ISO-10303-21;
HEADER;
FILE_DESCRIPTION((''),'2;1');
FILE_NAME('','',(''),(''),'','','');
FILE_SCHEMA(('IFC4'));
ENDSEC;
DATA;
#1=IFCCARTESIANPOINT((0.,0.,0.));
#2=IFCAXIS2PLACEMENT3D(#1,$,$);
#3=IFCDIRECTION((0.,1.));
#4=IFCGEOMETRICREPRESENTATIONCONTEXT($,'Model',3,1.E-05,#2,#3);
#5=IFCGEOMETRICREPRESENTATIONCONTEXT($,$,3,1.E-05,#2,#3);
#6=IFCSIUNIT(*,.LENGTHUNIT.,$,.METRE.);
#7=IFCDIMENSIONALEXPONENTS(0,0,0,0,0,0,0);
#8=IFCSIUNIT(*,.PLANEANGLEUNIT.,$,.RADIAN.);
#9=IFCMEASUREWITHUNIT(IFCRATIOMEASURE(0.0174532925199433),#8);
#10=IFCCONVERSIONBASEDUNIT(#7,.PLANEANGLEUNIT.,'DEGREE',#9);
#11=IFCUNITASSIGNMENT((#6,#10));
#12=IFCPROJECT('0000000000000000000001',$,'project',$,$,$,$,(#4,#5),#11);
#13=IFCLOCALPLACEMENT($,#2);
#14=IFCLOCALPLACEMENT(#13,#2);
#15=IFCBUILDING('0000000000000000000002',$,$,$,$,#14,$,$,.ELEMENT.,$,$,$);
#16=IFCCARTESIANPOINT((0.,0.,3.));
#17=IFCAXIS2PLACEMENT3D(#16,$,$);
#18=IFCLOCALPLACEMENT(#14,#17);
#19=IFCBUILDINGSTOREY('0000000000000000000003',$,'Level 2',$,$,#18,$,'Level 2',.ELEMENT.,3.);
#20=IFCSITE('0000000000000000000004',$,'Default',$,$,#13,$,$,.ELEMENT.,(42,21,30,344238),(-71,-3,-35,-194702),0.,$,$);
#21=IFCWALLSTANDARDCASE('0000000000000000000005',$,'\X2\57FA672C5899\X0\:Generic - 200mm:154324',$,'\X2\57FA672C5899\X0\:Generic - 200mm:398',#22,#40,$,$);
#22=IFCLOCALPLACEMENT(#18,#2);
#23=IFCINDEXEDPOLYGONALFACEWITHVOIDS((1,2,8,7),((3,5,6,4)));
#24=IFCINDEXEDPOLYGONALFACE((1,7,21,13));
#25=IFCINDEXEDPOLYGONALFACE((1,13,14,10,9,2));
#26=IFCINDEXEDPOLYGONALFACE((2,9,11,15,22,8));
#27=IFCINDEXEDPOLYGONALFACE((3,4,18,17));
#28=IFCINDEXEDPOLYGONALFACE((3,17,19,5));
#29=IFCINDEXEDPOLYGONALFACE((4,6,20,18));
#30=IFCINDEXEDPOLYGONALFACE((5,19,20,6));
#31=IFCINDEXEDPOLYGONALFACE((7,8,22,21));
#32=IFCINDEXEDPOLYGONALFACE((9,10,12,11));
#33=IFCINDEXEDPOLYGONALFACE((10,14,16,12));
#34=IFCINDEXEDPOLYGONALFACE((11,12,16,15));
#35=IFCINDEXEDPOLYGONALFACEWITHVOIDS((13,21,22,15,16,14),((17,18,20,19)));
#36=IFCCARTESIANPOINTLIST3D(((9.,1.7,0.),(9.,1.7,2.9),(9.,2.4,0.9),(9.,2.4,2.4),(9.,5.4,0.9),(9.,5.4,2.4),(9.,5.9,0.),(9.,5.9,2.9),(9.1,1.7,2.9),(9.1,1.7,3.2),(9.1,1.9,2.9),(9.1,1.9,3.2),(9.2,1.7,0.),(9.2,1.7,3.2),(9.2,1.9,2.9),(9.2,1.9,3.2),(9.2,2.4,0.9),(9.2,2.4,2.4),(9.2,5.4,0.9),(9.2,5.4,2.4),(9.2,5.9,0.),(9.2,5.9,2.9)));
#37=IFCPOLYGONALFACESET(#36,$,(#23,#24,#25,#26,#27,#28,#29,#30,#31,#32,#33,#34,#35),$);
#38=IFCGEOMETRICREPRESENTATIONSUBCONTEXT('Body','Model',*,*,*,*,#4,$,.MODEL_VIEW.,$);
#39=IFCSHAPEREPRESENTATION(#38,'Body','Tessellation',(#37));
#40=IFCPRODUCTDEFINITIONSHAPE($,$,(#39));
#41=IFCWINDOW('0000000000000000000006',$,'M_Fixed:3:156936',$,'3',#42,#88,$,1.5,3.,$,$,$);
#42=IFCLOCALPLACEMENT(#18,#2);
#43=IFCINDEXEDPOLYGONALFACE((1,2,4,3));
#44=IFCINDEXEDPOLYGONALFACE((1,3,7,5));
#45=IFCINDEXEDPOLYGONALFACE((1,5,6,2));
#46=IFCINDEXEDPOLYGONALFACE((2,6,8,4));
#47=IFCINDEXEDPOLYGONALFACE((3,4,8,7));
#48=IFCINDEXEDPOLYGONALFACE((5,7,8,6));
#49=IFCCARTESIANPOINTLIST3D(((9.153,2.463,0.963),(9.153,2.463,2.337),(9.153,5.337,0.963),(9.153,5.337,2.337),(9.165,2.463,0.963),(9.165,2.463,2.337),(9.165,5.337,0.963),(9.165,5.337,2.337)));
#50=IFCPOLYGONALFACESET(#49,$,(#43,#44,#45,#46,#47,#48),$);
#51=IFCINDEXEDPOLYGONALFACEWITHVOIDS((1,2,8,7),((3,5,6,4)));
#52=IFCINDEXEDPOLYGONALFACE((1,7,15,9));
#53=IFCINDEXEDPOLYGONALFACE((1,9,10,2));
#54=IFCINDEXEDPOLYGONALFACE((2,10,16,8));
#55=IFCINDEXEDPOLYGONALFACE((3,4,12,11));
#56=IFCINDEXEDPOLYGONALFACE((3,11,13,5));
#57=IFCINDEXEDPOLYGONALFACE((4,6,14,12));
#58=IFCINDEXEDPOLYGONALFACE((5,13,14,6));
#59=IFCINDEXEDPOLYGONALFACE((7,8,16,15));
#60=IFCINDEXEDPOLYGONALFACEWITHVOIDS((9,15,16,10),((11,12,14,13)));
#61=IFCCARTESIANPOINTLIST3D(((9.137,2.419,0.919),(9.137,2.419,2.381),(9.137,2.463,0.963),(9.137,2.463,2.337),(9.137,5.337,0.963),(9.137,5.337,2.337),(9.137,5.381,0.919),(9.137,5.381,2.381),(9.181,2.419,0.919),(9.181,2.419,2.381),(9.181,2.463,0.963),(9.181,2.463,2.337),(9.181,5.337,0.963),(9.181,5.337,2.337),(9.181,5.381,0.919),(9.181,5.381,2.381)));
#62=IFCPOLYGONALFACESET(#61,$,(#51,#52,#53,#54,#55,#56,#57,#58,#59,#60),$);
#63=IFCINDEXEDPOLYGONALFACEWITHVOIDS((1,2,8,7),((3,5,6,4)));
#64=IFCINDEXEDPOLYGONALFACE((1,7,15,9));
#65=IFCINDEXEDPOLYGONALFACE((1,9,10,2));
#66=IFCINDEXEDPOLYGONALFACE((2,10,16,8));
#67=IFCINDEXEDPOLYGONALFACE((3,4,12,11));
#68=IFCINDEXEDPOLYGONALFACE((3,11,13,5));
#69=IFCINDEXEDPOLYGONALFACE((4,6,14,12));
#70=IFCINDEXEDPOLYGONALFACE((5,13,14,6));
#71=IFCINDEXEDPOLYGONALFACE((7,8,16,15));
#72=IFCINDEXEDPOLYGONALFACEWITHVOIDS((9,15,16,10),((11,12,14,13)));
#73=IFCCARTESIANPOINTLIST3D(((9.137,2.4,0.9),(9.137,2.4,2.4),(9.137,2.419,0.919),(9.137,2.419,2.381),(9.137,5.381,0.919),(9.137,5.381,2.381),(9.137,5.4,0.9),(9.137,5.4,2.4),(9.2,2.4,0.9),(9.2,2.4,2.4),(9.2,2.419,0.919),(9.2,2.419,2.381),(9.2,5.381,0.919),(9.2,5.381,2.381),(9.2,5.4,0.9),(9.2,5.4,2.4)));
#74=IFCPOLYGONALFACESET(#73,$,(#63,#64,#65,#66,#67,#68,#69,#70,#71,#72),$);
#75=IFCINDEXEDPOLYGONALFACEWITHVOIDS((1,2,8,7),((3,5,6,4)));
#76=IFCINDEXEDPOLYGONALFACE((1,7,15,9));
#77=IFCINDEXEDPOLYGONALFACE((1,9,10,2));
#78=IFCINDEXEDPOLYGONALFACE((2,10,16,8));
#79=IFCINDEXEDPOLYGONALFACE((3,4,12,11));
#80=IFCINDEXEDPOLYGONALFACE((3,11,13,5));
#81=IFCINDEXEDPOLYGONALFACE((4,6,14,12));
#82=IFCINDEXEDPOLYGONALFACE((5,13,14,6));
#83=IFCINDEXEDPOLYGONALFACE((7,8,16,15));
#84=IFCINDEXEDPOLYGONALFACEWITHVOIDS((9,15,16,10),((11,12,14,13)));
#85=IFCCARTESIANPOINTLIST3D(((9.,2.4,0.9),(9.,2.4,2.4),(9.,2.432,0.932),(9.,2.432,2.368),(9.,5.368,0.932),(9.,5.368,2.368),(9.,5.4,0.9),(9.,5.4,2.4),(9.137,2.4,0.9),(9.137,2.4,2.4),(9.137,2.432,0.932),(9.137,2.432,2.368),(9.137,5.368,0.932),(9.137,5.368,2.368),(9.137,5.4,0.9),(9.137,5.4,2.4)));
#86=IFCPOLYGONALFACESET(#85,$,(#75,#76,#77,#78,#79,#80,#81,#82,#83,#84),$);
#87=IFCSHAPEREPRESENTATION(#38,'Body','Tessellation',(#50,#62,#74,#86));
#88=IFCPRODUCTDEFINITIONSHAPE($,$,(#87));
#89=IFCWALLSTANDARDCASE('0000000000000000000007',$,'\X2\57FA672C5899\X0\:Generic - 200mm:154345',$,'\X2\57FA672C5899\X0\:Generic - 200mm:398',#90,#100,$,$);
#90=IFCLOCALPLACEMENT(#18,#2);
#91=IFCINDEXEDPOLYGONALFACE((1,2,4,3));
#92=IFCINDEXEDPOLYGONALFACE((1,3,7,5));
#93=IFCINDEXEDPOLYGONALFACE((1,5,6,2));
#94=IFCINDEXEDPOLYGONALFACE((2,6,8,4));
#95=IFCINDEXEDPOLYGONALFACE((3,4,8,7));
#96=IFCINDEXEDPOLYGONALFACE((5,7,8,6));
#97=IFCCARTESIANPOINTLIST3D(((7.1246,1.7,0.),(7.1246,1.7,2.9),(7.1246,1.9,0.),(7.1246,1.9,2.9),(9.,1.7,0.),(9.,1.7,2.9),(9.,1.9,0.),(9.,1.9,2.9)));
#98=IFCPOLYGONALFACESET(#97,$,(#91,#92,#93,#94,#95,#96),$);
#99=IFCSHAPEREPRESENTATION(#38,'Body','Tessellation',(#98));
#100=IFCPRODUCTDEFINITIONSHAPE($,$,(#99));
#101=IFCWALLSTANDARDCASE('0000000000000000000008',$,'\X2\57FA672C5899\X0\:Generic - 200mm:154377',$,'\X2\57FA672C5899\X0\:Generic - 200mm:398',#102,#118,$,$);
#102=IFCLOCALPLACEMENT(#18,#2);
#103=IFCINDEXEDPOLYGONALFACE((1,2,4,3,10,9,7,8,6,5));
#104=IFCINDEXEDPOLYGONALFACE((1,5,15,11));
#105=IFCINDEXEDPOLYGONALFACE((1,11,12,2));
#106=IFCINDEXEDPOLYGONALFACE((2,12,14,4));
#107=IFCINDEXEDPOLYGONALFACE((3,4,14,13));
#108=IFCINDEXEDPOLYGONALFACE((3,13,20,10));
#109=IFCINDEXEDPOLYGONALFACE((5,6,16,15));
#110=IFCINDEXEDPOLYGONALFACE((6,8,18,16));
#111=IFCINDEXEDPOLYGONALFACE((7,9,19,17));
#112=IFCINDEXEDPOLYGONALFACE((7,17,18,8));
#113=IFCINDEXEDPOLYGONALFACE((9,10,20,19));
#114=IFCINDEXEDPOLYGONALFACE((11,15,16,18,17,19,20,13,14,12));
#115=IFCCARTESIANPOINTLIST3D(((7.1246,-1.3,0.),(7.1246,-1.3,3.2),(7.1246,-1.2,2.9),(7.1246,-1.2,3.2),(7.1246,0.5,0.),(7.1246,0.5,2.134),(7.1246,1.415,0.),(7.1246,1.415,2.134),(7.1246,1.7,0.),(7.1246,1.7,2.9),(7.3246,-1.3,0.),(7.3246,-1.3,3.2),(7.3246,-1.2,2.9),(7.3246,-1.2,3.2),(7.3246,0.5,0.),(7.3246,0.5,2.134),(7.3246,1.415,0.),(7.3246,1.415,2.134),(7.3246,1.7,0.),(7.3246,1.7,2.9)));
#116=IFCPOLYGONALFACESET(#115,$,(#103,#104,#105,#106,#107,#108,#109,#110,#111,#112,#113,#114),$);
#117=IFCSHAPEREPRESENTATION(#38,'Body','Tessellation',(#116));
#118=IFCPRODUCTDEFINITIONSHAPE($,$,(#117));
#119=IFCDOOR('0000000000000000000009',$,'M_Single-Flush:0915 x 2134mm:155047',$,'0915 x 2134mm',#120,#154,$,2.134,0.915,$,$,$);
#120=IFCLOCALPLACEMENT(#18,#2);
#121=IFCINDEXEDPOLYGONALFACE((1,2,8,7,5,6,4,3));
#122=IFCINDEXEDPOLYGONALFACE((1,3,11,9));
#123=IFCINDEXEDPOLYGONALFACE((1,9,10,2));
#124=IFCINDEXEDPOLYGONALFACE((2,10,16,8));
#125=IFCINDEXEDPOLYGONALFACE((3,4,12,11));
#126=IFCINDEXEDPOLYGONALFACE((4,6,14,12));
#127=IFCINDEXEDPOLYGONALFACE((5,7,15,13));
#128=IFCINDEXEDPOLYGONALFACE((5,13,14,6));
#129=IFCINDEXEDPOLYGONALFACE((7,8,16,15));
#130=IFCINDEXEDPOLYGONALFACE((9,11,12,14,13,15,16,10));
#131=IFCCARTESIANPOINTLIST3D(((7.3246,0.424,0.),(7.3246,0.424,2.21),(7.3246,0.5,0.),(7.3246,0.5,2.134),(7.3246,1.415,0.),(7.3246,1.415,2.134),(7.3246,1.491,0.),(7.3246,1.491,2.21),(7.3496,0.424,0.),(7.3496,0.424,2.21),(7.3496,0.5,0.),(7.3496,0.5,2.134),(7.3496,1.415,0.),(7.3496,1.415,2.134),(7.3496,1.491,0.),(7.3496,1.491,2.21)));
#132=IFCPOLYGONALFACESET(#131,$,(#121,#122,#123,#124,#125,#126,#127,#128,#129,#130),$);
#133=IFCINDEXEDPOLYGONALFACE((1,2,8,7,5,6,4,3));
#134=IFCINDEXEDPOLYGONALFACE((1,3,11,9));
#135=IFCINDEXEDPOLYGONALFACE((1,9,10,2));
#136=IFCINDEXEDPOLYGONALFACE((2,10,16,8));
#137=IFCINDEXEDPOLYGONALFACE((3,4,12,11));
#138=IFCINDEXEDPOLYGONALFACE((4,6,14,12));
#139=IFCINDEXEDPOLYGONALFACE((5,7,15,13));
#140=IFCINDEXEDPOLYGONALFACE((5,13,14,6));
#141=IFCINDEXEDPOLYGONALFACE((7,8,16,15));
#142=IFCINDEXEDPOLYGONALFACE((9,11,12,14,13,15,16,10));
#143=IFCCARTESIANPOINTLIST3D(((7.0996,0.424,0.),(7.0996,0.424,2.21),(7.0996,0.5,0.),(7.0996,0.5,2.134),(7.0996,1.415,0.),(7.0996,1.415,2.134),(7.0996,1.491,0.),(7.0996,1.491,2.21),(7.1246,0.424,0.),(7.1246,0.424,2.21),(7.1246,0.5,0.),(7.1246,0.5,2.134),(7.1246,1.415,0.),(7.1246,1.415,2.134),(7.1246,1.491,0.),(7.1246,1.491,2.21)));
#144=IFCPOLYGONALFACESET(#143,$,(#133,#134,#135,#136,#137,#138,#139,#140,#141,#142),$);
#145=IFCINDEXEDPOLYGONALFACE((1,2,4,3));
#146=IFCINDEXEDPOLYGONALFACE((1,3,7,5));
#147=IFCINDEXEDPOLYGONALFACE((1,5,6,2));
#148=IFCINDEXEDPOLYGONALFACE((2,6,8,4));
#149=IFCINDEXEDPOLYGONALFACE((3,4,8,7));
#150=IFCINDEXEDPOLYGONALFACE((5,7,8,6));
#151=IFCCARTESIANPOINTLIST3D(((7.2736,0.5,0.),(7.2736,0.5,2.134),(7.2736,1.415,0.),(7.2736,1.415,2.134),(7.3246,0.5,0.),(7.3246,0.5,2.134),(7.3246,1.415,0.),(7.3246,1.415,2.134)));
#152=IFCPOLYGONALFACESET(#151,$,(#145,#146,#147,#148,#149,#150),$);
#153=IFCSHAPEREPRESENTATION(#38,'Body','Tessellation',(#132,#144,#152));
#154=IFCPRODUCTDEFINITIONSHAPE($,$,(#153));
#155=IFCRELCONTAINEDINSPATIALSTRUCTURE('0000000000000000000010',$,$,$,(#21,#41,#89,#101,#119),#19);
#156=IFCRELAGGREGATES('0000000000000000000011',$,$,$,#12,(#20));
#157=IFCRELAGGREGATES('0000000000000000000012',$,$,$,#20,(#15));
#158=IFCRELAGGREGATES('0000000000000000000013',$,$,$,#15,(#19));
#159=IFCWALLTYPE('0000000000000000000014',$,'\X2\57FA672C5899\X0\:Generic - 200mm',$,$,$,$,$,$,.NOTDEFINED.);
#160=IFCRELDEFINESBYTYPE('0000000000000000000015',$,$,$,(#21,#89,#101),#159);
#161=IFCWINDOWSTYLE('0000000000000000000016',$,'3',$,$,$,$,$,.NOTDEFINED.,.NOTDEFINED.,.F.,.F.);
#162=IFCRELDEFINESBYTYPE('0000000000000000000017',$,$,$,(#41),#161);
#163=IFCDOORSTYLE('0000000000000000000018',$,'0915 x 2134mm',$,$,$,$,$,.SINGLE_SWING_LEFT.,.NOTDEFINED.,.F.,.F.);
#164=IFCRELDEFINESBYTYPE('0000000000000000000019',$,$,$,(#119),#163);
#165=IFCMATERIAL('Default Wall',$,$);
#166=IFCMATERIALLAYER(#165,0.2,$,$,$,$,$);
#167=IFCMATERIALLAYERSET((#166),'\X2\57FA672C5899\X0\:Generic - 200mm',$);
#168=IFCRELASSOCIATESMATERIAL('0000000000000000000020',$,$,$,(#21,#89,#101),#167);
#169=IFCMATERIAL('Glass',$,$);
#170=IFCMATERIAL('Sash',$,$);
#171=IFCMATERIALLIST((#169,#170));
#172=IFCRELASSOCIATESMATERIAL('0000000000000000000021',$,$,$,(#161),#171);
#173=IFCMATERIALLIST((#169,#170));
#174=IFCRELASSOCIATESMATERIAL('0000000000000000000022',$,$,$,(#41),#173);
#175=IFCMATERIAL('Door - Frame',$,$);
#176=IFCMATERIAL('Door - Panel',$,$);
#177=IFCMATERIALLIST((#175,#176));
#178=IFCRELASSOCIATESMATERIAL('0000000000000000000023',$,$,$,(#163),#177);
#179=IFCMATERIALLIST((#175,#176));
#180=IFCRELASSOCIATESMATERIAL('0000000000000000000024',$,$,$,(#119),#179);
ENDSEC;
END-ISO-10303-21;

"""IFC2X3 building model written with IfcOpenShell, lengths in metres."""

from ifc_helpers import new_model, entity, si_unit, converted_unit, direction, frame, frame_2d, origin, place, context, subcontext, project, spatial, polyline, rectangle, outline, extrude, clip, bounded_halfspace, source, transform, mapped, material, material_list, layer, layer_set, layer_usage, type_object, type_shapes, element, fill, save


model = new_model("IFC2X3")

# Units and contexts
model_context = context("Model", 3, precision=1e-05, world=origin(), true_north=direction((0.0, 1.0)))
context_of_model = context(None, 3, precision=1e-05, world=origin(), true_north=direction((0.0, 1.0)))
body_context = subcontext(model_context, "Body", "Model", "MODEL_VIEW")
ifc_project = project(units=[si_unit("LENGTHUNIT", "METRE"), converted_unit("PLANEANGLEUNIT", "DEGREE", entity("IfcRatioMeasure", 0.0174532925199433), si_unit("PLANEANGLEUNIT", "RADIAN"), dimensions=[0, 0, 0, 0, 0, 0, 0])], contexts=[model_context, context_of_model])

# Site, building, storey
site_placement = place(None, origin())
site = spatial("IfcSite", under=ifc_project, at=site_placement, Name="Default", CompositionType="ELEMENT", RefLatitude=(42, 21, 30, 344238), RefLongitude=(-71, -3, -35, -194702), RefElevation=0.0)
building_placement = place(site_placement, origin())
building = spatial("IfcBuilding", under=site, at=building_placement, CompositionType="ELEMENT")
storey_placement = place(building_placement, frame((0.0, 0.0, 3.0)))
storey = spatial("IfcBuildingStorey", under=building, at=storey_placement, Name="Level 2", LongName="Level 2", CompositionType="ELEMENT", Elevation=3.0)

# Shared definitions
ifc_material_1 = material(Name="Default Wall")
ifc_layer_1 = layer(ifc_material_1, 0.2)
ifc_layer_set_1 = layer_set([ifc_layer_1], Name="基本墙:Generic - 200mm")
wall_type_1 = type_object("IfcWallType", Name="基本墙:Generic - 200mm", PredefinedType="NOTDEFINED")
ifc_material_2 = material(Name="Glass")
ifc_material_3 = material(Name="Door - Panel")
ifc_material_4 = material(Name="Door - Frame")

# Wall, opening, window
ifc_layer_usage_1 = layer_usage(ifc_layer_set_1, "AXIS2", "NEGATIVE", 0.1)
wall_1_placement = place(storey_placement, frame((9.1, 5.9, 0.0), z_axis=(0.0, 0.0, 1.0), x_axis=(0.0, -1.0, 0.0)))
wall_1 = element("IfcWallStandardCase", 1, at=wall_1_placement, inside=storey, type_object=wall_type_1, material=ifc_layer_usage_1, Name="基本墙:Generic - 200mm:154324", ObjectType="基本墙:Generic - 200mm:398", context=body_context, shape_type="Clipping", body=[
    clip(clip(clip(extrude(rectangle(XDim=4.2, YDim=0.2, at=frame_2d((2.1, 0.0), x_axis=(-1.0, 0.0))), origin(), (0.0, 0.0, 1.0), 3.2), bounded_halfspace(frame((4.2, -0.1, 2.9), z_axis=(0.0, 0.0, -1.0), x_axis=(1.0, 0.0, 0.0)), True, frame((4.2, -0.1, 2.9), z_axis=(0.0, 0.0, -1.0), x_axis=(1.0, 0.0, 0.0)), polyline([(0.0, 0.0), (-0.2, 0.0), (-4.2, 0.0), (-4.2, -0.2), (-0.2, -0.2), (-0.2, -0.1), (0.0, -0.1), (0.0, 0.0)]))), bounded_halfspace(frame((4.2, 0.0, 2.9), z_axis=(0.0, 1.0, 0.0), x_axis=(0.0, 0.0, 1.0)), True, frame((4.2, 0.0, 2.9), z_axis=(0.0, 1.0, 0.0), x_axis=(0.0, 0.0, 1.0)), polyline([(0.0, 0.0), (0.0, -0.2), (0.3, -0.2), (0.3, -0.0229), (0.3, 0.0), (0.0, 0.0)]))), bounded_halfspace(frame((4.0, 0.1, 2.9), z_axis=(-1.0, 0.0, 0.0), x_axis=(0.0, -1.0, 0.0)), False, frame((4.0, 0.1, 2.9), z_axis=(-1.0, 0.0, 0.0), x_axis=(0.0, -1.0, 0.0)), polyline([(0.0, 0.0), (0.1, 0.0), (0.1, 0.3), (0.0, 0.3), (0.0, 0.0)]))),
])
opening_1_placement = place(wall_1_placement, frame((0.5, -0.1, 0.9)))
opening_1 = element("IfcOpeningElement", 2, at=opening_1_placement, cuts=wall_1, ObjectType="Opening", context=body_context, shape_type="SweptSolid", body=[
    extrude(rectangle(XDim=1.5, YDim=3.0, at=frame_2d((0.75, 1.5), x_axis=(1.0, 0.0))), frame((0.0, 0.0, 0.0), z_axis=(0.0, 1.0, 0.0), x_axis=(0.0, 0.0, 1.0)), (0.0, 0.0, 1.0), 0.2),
])
ifc_material_5 = material(Name="Sash")
ifc_material_list_1 = material_list([ifc_material_2, ifc_material_5])
ifc_material_list_2 = material_list([ifc_material_2, ifc_material_5])
window_style_1 = type_object("IfcWindowStyle", Name="3", ConstructionType="NOTDEFINED", OperationType="NOTDEFINED", ParameterTakesPrecedence=False, Sizeable=False, material=ifc_material_list_2)
shared_shape_1 = source(origin(), body_context, "Body", "SweptSolid", [
    extrude(rectangle(XDim=0.012, YDim=2.874, at=frame_2d((0.0, 0.0), x_axis=(1.0, 0.0))), frame((1.5, 0.159, 0.063), z_axis=(0.0, 0.0, 1.0), x_axis=(0.0, -1.0, 0.0)), (0.0, 0.0, 1.0), 1.374),
    extrude(outline(polyline([(-1.481, -0.731), (1.481, -0.731), (1.481, 0.731), (-1.481, 0.731), (-1.481, -0.731)]), holes=[polyline([(-1.437, -0.687), (-1.437, 0.687), (1.437, 0.687), (1.437, -0.687), (-1.437, -0.687)])]), frame((1.5, 0.137, 0.75), z_axis=(0.0, 1.0, 0.0), x_axis=(1.0, 0.0, 0.0)), (0.0, 0.0, 1.0), 0.044),
    extrude(outline(polyline([(-1.5, -0.75), (1.5, -0.75), (1.5, 0.75), (-1.5, 0.75), (-1.5, -0.75)]), holes=[polyline([(-1.481, -0.731), (-1.481, 0.731), (1.481, 0.731), (1.481, -0.731), (-1.481, -0.731)])]), frame((1.5, 0.137, 0.75), z_axis=(0.0, 1.0, 0.0), x_axis=(1.0, 0.0, 0.0)), (0.0, 0.0, 1.0), 0.063),
    extrude(outline(polyline([(-1.5, -0.75), (1.5, -0.75), (1.5, 0.75), (-1.5, 0.75), (-1.5, -0.75)]), holes=[polyline([(-1.468, -0.718), (-1.468, 0.718), (1.468, 0.718), (1.468, -0.718), (-1.468, -0.718)])]), frame((1.5, 0.0, 0.75), z_axis=(0.0, 1.0, 0.0), x_axis=(1.0, 0.0, 0.0)), (0.0, 0.0, 1.0), 0.137),
])
type_shapes(window_style_1, [shared_shape_1])
window_1_placement = place(opening_1_placement, origin())
window_1 = element("IfcWindow", 3, at=window_1_placement, inside=storey, type_object=window_style_1, material=ifc_material_list_1, Name="M_Fixed:3:156936", ObjectType="3", OverallHeight=1.5, OverallWidth=3.0, context=body_context, shape_type="MappedRepresentation", body=[
    mapped(shared_shape_1, transform((0.0, 0.0, 0.0), scale=1.0)),
])
fill(opening_1, window_1)

# Wall
ifc_layer_usage_2 = layer_usage(ifc_layer_set_1, "AXIS2", "NEGATIVE", 0.1)
wall_2_placement = place(storey_placement, frame((9.0, 1.8, 0.0), z_axis=(0.0, 0.0, 1.0), x_axis=(-1.0, 0.0, 0.0)))
element("IfcWallStandardCase", 4, at=wall_2_placement, inside=storey, type_object=wall_type_1, material=ifc_layer_usage_2, Name="基本墙:Generic - 200mm:154345", ObjectType="基本墙:Generic - 200mm:398", context=body_context, shape_type="Clipping", body=[
    clip(extrude(rectangle(XDim=1.8754, YDim=0.2, at=frame_2d((0.9377, 0.0), x_axis=(-1.0, 0.0))), origin(), (0.0, 0.0, 1.0), 3.2), bounded_halfspace(frame((0.0, -0.1, 2.9), z_axis=(0.0, 0.0, -1.0), x_axis=(0.0, 1.0, 0.0)), True, frame((0.0, -0.1, 2.9), z_axis=(0.0, 0.0, -1.0), x_axis=(0.0, 1.0, 0.0)), polyline([(0.0, 0.0), (0.2, 0.0), (0.2, 1.6754), (0.2, 1.8754), (0.0, 1.8754), (0.0, 0.0)]))),
])

# Wall, opening, door
ifc_layer_usage_3 = layer_usage(ifc_layer_set_1, "AXIS2", "NEGATIVE", 0.1)
wall_3_placement = place(storey_placement, frame((7.2246, 1.7, 0.0), z_axis=(0.0, 0.0, 1.0), x_axis=(0.0, -1.0, 0.0)))
wall_3 = element("IfcWallStandardCase", 5, at=wall_3_placement, inside=storey, type_object=wall_type_1, material=ifc_layer_usage_3, Name="基本墙:Generic - 200mm:154377", ObjectType="基本墙:Generic - 200mm:398", context=body_context, shape_type="Clipping", body=[
    clip(clip(extrude(rectangle(XDim=3.0, YDim=0.2, at=frame_2d((1.5, 0.0), x_axis=(-1.0, 0.0))), origin(), (0.0, 0.0, 1.0), 3.2), bounded_halfspace(frame((2.9, -0.1, 2.9), z_axis=(0.0, 0.0, -1.0), x_axis=(1.0, 0.0, 0.0)), True, frame((2.9, -0.1, 2.9), z_axis=(0.0, 0.0, -1.0), x_axis=(1.0, 0.0, 0.0)), polyline([(0.0, 0.0), (-0.1, 0.0), (-2.9, 0.0), (-2.9, -0.2), (0.0, -0.2), (0.0, 0.0)]))), bounded_halfspace(frame((2.9, 0.1, 2.9), z_axis=(1.0, 0.0, 0.0), x_axis=(0.0, 0.0, 1.0)), True, frame((2.9, 0.1, 2.9), z_axis=(1.0, 0.0, 0.0), x_axis=(0.0, 0.0, 1.0)), polyline([(0.0, 0.0), (0.3, 0.0), (0.3, 0.2), (0.0, 0.2), (0.0, 0.0)]))),
])
opening_2_placement = place(wall_3_placement, frame((0.285, -0.1, 0.0)))
opening_2 = element("IfcOpeningElement", 6, at=opening_2_placement, cuts=wall_3, ObjectType="Opening", context=body_context, shape_type="SweptSolid", body=[
    extrude(rectangle(XDim=0.915, YDim=2.134, at=frame_2d((1.067, 0.4575), x_axis=(0.0, -1.0))), frame((0.0, 0.0, 0.0), z_axis=(0.0, 1.0, 0.0), x_axis=(0.0, 0.0, 1.0)), (0.0, 0.0, 1.0), 0.2),
])
ifc_material_list_3 = material_list([ifc_material_4, ifc_material_3])
ifc_material_list_4 = material_list([ifc_material_4, ifc_material_3])
door_style_1 = type_object("IfcDoorStyle", Name="0915 x 2134mm", ConstructionType="NOTDEFINED", OperationType="SINGLE_SWING_LEFT", ParameterTakesPrecedence=False, Sizeable=False, material=ifc_material_list_4)
shared_shape_2 = source(origin(), body_context, "Body", "SweptSolid", [
    extrude(outline(polyline([(-0.5335, -1.124), (0.5335, -1.124), (0.5335, 1.086), (0.4575, 1.086), (0.4575, -1.048), (-0.4575, -1.048), (-0.4575, 1.086), (-0.5335, 1.086), (-0.5335, -1.124)])), frame((0.4575, 0.225, 1.086), z_axis=(0.0, -1.0, 0.0), x_axis=(-1.0, 0.0, 0.0)), (0.0, 0.0, 1.0), 0.025),
    extrude(outline(polyline([(-1.124, -0.5335), (1.086, -0.5335), (1.086, -0.4575), (-1.048, -0.4575), (-1.048, 0.4575), (1.086, 0.4575), (1.086, 0.5335), (-1.124, 0.5335), (-1.124, -0.5335)])), frame((0.4575, 0.0, 1.086), z_axis=(0.0, -1.0, 0.0), x_axis=(0.0, 0.0, -1.0)), (0.0, 0.0, 1.0), 0.025),
    extrude(rectangle(XDim=0.915, YDim=0.051, at=frame_2d((0.0, 0.0), x_axis=(1.0, 0.0))), frame((0.4575, 0.1745, 0.0)), (0.0, 0.0, 1.0), 2.134),
])
type_shapes(door_style_1, [shared_shape_2])
door_1_placement = place(opening_2_placement, origin())
door_1 = element("IfcDoor", 7, at=door_1_placement, inside=storey, type_object=door_style_1, material=ifc_material_list_3, Name="M_Single-Flush:0915 x 2134mm:155047", ObjectType="0915 x 2134mm", OverallHeight=2.134, OverallWidth=0.915, context=body_context, shape_type="MappedRepresentation", body=[
    mapped(shared_shape_2, transform((0.0, 0.0, 0.0), scale=1.0)),
])
fill(opening_2, door_1)

save(model, "model.ifc")
